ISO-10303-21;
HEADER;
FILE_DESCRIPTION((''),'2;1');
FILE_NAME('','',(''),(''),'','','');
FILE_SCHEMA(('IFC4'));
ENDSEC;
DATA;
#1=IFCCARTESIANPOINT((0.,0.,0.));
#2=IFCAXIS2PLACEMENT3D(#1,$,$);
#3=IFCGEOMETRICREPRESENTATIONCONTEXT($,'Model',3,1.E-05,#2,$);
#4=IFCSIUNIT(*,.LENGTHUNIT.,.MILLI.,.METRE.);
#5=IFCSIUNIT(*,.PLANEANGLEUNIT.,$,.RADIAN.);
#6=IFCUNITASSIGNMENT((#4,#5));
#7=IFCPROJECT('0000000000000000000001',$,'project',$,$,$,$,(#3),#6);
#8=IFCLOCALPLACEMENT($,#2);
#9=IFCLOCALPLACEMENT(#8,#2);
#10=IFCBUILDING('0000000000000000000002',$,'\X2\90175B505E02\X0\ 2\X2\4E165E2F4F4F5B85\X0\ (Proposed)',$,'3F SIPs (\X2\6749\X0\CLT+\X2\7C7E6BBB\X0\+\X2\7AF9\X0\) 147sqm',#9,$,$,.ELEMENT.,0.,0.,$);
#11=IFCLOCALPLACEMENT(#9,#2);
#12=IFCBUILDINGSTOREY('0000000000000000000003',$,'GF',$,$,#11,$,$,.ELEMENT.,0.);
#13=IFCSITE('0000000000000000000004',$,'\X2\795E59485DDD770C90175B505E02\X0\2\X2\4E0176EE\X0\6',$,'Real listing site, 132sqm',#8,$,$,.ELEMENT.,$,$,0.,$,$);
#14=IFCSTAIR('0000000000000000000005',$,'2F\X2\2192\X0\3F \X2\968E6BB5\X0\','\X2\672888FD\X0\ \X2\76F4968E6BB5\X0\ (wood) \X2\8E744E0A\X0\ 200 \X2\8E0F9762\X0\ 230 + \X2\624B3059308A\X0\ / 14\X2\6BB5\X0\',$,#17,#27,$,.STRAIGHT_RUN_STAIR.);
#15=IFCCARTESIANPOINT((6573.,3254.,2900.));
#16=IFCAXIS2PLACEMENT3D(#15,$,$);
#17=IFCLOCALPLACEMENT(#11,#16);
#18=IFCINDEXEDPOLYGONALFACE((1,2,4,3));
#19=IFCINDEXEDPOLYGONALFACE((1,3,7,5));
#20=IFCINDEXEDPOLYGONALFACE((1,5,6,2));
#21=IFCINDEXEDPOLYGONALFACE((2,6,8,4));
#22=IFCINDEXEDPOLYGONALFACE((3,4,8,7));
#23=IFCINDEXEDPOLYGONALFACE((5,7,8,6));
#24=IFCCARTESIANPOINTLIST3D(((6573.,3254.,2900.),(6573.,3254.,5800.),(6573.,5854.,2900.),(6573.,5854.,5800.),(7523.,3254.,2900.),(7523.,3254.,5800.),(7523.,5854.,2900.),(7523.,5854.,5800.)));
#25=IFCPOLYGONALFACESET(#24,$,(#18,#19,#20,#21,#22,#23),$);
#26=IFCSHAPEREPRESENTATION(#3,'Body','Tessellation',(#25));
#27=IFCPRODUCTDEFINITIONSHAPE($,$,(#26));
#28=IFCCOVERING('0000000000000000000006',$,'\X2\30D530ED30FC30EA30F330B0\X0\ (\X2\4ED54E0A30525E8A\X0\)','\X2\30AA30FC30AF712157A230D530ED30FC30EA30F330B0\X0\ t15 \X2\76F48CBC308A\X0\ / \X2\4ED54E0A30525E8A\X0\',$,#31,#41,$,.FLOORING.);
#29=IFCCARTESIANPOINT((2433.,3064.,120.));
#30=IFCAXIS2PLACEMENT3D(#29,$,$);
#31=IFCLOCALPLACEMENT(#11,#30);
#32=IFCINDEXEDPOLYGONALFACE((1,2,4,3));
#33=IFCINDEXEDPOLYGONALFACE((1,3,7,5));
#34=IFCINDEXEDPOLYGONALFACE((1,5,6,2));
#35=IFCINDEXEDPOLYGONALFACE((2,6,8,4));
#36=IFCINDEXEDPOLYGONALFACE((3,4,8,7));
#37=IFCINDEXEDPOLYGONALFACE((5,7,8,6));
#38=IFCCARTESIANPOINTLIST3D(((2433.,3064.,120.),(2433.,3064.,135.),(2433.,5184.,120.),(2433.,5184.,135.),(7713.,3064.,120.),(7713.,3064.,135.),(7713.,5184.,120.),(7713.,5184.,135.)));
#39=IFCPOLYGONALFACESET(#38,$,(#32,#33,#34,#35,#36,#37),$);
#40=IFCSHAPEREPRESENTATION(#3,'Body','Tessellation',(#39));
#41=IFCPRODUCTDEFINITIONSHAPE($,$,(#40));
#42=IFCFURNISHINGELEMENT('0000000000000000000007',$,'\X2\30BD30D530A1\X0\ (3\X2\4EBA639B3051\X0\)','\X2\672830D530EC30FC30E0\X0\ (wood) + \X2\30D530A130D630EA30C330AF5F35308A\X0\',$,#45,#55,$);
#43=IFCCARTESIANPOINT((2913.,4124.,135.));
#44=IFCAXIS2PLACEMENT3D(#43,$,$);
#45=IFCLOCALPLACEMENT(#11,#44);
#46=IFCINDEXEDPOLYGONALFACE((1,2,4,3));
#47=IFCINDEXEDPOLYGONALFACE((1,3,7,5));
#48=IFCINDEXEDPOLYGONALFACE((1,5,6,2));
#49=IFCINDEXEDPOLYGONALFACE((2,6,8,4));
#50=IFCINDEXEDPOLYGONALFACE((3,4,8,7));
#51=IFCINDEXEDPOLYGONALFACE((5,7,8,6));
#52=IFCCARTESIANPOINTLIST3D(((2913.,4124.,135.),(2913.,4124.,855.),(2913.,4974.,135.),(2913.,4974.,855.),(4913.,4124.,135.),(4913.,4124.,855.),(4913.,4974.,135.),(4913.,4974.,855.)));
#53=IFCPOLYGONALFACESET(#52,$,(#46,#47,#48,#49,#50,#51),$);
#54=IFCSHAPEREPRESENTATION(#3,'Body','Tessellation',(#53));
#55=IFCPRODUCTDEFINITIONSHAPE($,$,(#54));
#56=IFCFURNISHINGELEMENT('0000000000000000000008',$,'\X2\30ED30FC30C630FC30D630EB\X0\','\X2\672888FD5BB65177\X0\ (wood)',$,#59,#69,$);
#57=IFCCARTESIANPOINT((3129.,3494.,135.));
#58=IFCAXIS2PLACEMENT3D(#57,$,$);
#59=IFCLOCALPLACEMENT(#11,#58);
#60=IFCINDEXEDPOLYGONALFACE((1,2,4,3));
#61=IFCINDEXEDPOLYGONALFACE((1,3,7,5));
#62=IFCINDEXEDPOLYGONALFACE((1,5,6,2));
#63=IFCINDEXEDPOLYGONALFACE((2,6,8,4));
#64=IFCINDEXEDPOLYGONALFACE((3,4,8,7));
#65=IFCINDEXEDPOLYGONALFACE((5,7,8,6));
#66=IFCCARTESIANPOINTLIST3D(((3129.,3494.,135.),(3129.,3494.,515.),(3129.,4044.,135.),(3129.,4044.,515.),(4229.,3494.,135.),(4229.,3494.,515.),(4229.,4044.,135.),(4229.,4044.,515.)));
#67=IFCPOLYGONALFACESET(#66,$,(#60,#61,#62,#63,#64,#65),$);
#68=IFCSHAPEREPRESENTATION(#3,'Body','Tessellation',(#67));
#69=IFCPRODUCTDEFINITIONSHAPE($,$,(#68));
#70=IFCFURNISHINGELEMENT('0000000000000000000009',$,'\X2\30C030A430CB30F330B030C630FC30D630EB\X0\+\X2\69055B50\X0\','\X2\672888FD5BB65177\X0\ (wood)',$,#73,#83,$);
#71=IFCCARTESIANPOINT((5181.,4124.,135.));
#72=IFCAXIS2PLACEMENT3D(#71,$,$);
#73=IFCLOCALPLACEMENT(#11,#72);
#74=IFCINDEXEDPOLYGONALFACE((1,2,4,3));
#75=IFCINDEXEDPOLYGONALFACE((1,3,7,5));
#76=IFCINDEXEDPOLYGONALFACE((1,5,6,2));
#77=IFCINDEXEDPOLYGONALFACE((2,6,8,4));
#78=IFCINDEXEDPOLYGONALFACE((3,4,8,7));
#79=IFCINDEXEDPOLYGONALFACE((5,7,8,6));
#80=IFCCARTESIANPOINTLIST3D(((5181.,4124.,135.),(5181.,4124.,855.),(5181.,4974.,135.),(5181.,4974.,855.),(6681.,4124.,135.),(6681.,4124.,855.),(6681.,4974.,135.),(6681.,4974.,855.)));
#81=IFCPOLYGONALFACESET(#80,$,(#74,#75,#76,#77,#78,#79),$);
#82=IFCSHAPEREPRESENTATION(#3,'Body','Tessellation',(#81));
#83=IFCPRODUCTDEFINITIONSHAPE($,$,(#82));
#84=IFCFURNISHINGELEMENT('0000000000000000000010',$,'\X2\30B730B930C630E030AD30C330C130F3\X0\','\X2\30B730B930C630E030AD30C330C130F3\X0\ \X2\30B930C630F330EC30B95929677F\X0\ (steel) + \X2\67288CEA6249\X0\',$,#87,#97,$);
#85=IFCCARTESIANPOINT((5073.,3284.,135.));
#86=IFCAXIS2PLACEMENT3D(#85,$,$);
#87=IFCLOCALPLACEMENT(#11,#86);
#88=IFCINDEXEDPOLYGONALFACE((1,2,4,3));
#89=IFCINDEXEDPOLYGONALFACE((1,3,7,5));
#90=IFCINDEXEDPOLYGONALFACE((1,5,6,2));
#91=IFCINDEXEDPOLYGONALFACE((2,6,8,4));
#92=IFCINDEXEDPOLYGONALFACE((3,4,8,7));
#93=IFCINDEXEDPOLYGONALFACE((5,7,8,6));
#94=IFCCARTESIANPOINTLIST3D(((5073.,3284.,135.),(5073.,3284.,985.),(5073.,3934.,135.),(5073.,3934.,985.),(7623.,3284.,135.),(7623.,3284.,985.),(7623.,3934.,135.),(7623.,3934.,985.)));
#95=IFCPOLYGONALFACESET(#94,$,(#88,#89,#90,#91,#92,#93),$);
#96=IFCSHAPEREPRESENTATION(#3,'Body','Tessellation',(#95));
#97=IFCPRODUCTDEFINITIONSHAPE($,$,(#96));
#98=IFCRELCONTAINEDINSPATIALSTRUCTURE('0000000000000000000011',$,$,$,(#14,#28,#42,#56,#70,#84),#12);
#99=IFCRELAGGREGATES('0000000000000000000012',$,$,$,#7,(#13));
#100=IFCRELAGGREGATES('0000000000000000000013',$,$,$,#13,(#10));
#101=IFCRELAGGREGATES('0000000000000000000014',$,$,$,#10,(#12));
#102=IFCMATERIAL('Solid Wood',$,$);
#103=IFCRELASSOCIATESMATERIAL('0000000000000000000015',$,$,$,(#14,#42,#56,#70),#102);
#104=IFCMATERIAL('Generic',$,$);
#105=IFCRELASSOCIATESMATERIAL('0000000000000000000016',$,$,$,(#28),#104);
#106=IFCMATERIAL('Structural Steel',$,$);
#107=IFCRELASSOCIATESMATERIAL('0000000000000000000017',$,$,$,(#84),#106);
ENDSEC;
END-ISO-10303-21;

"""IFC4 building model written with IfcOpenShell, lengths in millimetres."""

from ifc_helpers import new_model, si_unit, frame, frame_2d, origin, place, context, project, spatial, rectangle, extrude, material, element, save


model = new_model("IFC4")

# Units and contexts
model_context = context("Model", 3, precision=1e-05, world=origin())
ifc_project = project(units=[si_unit("LENGTHUNIT", "METRE", prefix="MILLI"), si_unit("PLANEANGLEUNIT", "RADIAN")], contexts=[model_context])

# Site, building, storey
site_placement = place(None, origin())
site = spatial("IfcSite", under=ifc_project, at=site_placement, Name="神奈川県逗子市2丁目6", ObjectType="Real listing site, 132sqm", CompositionType="ELEMENT", RefElevation=0.0)
building_placement = place(site_placement, origin())
building = spatial("IfcBuilding", under=site, at=building_placement, Name="逗子市 2世帯住宅 (Proposed)", ObjectType="3F SIPs (杉CLT+籾殻+竹) 147sqm", CompositionType="ELEMENT", ElevationOfRefHeight=0.0, ElevationOfTerrain=0.0)
storey_placement = place(building_placement, origin())
storey = spatial("IfcBuildingStorey", under=building, at=storey_placement, Name="GF", CompositionType="ELEMENT", Elevation=0.0)

# Shared definitions
ifc_material_1 = material(Name="Solid Wood")
ifc_material_2 = material(Name="Generic")

# Stair
stair_1_placement = place(storey_placement, frame((6573.0, 3254.0, 2900.0)))
element("IfcStair", 1, at=stair_1_placement, inside=storey, material=ifc_material_1, Name="2F→3F 階段", Description="木製 直階段 (wood) 蹴上 200 踏面 230 + 手すり / 14段", PredefinedType="STRAIGHT_RUN_STAIR", context=model_context, shape_type="SweptSolid", body=[
    extrude(rectangle(XDim=950.0, YDim=2600.0, at=frame_2d((475.0, 1300.0))), frame((6573.0, 3254.0, 2900.0)), (0.0, 0.0, 1.0), 2900.0),
])

# Covering
covering_placement = place(storey_placement, frame((2433.0, 3064.0, 120.0)))
element("IfcCovering", 2, at=covering_placement, inside=storey, material=ifc_material_2, Name="フローリング (仕上げ床)", Description="オーク無垢フローリング t15 直貼り / 仕上げ床", PredefinedType="FLOORING", context=model_context, shape_type="SweptSolid", body=[
    extrude(rectangle(XDim=5280.0, YDim=2120.0, at=frame_2d((2640.0, 1060.0))), frame((2433.0, 3064.0, 120.0)), (0.0, 0.0, 1.0), 15.0),
])

# Furnishing elements
furnishing_1_placement = place(storey_placement, frame((2913.0, 4124.0, 135.0)))
element("IfcFurnishingElement", 3, at=furnishing_1_placement, inside=storey, material=ifc_material_1, Name="ソファ (3人掛け)", Description="木フレーム (wood) + ファブリック張り", context=model_context, shape_type="SweptSolid", body=[
    extrude(rectangle(XDim=2000.0, YDim=850.0, at=frame_2d((1000.0, 425.0))), frame((2913.0, 4124.0, 135.0)), (0.0, 0.0, 1.0), 720.0),
])
furnishing_2_placement = place(storey_placement, frame((3129.0, 3494.0, 135.0)))
element("IfcFurnishingElement", 4, at=furnishing_2_placement, inside=storey, material=ifc_material_1, Name="ローテーブル", Description="木製家具 (wood)", context=model_context, shape_type="SweptSolid", body=[
    extrude(rectangle(XDim=1100.0, YDim=550.0, at=frame_2d((550.0, 275.0))), frame((3129.0, 3494.0, 135.0)), (0.0, 0.0, 1.0), 380.0),
])
furnishing_3_placement = place(storey_placement, frame((5181.0, 4124.0, 135.0)))
element("IfcFurnishingElement", 5, at=furnishing_3_placement, inside=storey, material=ifc_material_1, Name="ダイニングテーブル+椅子", Description="木製家具 (wood)", context=model_context, shape_type="SweptSolid", body=[
    extrude(rectangle(XDim=1500.0, YDim=850.0, at=frame_2d((750.0, 425.0))), frame((5181.0, 4124.0, 135.0)), (0.0, 0.0, 1.0), 720.0),
])
ifc_material_3 = material(Name="Structural Steel")
furnishing_4_placement = place(storey_placement, frame((5073.0, 3284.0, 135.0)))
element("IfcFurnishingElement", 6, at=furnishing_4_placement, inside=storey, material=ifc_material_3, Name="システムキッチン", Description="システムキッチン ステンレス天板 (steel) + 木質扉", context=model_context, shape_type="SweptSolid", body=[
    extrude(rectangle(XDim=2550.0, YDim=650.0, at=frame_2d((1275.0, 325.0))), frame((5073.0, 3284.0, 135.0)), (0.0, 0.0, 1.0), 850.0),
])

save(model, "model.ifc")
